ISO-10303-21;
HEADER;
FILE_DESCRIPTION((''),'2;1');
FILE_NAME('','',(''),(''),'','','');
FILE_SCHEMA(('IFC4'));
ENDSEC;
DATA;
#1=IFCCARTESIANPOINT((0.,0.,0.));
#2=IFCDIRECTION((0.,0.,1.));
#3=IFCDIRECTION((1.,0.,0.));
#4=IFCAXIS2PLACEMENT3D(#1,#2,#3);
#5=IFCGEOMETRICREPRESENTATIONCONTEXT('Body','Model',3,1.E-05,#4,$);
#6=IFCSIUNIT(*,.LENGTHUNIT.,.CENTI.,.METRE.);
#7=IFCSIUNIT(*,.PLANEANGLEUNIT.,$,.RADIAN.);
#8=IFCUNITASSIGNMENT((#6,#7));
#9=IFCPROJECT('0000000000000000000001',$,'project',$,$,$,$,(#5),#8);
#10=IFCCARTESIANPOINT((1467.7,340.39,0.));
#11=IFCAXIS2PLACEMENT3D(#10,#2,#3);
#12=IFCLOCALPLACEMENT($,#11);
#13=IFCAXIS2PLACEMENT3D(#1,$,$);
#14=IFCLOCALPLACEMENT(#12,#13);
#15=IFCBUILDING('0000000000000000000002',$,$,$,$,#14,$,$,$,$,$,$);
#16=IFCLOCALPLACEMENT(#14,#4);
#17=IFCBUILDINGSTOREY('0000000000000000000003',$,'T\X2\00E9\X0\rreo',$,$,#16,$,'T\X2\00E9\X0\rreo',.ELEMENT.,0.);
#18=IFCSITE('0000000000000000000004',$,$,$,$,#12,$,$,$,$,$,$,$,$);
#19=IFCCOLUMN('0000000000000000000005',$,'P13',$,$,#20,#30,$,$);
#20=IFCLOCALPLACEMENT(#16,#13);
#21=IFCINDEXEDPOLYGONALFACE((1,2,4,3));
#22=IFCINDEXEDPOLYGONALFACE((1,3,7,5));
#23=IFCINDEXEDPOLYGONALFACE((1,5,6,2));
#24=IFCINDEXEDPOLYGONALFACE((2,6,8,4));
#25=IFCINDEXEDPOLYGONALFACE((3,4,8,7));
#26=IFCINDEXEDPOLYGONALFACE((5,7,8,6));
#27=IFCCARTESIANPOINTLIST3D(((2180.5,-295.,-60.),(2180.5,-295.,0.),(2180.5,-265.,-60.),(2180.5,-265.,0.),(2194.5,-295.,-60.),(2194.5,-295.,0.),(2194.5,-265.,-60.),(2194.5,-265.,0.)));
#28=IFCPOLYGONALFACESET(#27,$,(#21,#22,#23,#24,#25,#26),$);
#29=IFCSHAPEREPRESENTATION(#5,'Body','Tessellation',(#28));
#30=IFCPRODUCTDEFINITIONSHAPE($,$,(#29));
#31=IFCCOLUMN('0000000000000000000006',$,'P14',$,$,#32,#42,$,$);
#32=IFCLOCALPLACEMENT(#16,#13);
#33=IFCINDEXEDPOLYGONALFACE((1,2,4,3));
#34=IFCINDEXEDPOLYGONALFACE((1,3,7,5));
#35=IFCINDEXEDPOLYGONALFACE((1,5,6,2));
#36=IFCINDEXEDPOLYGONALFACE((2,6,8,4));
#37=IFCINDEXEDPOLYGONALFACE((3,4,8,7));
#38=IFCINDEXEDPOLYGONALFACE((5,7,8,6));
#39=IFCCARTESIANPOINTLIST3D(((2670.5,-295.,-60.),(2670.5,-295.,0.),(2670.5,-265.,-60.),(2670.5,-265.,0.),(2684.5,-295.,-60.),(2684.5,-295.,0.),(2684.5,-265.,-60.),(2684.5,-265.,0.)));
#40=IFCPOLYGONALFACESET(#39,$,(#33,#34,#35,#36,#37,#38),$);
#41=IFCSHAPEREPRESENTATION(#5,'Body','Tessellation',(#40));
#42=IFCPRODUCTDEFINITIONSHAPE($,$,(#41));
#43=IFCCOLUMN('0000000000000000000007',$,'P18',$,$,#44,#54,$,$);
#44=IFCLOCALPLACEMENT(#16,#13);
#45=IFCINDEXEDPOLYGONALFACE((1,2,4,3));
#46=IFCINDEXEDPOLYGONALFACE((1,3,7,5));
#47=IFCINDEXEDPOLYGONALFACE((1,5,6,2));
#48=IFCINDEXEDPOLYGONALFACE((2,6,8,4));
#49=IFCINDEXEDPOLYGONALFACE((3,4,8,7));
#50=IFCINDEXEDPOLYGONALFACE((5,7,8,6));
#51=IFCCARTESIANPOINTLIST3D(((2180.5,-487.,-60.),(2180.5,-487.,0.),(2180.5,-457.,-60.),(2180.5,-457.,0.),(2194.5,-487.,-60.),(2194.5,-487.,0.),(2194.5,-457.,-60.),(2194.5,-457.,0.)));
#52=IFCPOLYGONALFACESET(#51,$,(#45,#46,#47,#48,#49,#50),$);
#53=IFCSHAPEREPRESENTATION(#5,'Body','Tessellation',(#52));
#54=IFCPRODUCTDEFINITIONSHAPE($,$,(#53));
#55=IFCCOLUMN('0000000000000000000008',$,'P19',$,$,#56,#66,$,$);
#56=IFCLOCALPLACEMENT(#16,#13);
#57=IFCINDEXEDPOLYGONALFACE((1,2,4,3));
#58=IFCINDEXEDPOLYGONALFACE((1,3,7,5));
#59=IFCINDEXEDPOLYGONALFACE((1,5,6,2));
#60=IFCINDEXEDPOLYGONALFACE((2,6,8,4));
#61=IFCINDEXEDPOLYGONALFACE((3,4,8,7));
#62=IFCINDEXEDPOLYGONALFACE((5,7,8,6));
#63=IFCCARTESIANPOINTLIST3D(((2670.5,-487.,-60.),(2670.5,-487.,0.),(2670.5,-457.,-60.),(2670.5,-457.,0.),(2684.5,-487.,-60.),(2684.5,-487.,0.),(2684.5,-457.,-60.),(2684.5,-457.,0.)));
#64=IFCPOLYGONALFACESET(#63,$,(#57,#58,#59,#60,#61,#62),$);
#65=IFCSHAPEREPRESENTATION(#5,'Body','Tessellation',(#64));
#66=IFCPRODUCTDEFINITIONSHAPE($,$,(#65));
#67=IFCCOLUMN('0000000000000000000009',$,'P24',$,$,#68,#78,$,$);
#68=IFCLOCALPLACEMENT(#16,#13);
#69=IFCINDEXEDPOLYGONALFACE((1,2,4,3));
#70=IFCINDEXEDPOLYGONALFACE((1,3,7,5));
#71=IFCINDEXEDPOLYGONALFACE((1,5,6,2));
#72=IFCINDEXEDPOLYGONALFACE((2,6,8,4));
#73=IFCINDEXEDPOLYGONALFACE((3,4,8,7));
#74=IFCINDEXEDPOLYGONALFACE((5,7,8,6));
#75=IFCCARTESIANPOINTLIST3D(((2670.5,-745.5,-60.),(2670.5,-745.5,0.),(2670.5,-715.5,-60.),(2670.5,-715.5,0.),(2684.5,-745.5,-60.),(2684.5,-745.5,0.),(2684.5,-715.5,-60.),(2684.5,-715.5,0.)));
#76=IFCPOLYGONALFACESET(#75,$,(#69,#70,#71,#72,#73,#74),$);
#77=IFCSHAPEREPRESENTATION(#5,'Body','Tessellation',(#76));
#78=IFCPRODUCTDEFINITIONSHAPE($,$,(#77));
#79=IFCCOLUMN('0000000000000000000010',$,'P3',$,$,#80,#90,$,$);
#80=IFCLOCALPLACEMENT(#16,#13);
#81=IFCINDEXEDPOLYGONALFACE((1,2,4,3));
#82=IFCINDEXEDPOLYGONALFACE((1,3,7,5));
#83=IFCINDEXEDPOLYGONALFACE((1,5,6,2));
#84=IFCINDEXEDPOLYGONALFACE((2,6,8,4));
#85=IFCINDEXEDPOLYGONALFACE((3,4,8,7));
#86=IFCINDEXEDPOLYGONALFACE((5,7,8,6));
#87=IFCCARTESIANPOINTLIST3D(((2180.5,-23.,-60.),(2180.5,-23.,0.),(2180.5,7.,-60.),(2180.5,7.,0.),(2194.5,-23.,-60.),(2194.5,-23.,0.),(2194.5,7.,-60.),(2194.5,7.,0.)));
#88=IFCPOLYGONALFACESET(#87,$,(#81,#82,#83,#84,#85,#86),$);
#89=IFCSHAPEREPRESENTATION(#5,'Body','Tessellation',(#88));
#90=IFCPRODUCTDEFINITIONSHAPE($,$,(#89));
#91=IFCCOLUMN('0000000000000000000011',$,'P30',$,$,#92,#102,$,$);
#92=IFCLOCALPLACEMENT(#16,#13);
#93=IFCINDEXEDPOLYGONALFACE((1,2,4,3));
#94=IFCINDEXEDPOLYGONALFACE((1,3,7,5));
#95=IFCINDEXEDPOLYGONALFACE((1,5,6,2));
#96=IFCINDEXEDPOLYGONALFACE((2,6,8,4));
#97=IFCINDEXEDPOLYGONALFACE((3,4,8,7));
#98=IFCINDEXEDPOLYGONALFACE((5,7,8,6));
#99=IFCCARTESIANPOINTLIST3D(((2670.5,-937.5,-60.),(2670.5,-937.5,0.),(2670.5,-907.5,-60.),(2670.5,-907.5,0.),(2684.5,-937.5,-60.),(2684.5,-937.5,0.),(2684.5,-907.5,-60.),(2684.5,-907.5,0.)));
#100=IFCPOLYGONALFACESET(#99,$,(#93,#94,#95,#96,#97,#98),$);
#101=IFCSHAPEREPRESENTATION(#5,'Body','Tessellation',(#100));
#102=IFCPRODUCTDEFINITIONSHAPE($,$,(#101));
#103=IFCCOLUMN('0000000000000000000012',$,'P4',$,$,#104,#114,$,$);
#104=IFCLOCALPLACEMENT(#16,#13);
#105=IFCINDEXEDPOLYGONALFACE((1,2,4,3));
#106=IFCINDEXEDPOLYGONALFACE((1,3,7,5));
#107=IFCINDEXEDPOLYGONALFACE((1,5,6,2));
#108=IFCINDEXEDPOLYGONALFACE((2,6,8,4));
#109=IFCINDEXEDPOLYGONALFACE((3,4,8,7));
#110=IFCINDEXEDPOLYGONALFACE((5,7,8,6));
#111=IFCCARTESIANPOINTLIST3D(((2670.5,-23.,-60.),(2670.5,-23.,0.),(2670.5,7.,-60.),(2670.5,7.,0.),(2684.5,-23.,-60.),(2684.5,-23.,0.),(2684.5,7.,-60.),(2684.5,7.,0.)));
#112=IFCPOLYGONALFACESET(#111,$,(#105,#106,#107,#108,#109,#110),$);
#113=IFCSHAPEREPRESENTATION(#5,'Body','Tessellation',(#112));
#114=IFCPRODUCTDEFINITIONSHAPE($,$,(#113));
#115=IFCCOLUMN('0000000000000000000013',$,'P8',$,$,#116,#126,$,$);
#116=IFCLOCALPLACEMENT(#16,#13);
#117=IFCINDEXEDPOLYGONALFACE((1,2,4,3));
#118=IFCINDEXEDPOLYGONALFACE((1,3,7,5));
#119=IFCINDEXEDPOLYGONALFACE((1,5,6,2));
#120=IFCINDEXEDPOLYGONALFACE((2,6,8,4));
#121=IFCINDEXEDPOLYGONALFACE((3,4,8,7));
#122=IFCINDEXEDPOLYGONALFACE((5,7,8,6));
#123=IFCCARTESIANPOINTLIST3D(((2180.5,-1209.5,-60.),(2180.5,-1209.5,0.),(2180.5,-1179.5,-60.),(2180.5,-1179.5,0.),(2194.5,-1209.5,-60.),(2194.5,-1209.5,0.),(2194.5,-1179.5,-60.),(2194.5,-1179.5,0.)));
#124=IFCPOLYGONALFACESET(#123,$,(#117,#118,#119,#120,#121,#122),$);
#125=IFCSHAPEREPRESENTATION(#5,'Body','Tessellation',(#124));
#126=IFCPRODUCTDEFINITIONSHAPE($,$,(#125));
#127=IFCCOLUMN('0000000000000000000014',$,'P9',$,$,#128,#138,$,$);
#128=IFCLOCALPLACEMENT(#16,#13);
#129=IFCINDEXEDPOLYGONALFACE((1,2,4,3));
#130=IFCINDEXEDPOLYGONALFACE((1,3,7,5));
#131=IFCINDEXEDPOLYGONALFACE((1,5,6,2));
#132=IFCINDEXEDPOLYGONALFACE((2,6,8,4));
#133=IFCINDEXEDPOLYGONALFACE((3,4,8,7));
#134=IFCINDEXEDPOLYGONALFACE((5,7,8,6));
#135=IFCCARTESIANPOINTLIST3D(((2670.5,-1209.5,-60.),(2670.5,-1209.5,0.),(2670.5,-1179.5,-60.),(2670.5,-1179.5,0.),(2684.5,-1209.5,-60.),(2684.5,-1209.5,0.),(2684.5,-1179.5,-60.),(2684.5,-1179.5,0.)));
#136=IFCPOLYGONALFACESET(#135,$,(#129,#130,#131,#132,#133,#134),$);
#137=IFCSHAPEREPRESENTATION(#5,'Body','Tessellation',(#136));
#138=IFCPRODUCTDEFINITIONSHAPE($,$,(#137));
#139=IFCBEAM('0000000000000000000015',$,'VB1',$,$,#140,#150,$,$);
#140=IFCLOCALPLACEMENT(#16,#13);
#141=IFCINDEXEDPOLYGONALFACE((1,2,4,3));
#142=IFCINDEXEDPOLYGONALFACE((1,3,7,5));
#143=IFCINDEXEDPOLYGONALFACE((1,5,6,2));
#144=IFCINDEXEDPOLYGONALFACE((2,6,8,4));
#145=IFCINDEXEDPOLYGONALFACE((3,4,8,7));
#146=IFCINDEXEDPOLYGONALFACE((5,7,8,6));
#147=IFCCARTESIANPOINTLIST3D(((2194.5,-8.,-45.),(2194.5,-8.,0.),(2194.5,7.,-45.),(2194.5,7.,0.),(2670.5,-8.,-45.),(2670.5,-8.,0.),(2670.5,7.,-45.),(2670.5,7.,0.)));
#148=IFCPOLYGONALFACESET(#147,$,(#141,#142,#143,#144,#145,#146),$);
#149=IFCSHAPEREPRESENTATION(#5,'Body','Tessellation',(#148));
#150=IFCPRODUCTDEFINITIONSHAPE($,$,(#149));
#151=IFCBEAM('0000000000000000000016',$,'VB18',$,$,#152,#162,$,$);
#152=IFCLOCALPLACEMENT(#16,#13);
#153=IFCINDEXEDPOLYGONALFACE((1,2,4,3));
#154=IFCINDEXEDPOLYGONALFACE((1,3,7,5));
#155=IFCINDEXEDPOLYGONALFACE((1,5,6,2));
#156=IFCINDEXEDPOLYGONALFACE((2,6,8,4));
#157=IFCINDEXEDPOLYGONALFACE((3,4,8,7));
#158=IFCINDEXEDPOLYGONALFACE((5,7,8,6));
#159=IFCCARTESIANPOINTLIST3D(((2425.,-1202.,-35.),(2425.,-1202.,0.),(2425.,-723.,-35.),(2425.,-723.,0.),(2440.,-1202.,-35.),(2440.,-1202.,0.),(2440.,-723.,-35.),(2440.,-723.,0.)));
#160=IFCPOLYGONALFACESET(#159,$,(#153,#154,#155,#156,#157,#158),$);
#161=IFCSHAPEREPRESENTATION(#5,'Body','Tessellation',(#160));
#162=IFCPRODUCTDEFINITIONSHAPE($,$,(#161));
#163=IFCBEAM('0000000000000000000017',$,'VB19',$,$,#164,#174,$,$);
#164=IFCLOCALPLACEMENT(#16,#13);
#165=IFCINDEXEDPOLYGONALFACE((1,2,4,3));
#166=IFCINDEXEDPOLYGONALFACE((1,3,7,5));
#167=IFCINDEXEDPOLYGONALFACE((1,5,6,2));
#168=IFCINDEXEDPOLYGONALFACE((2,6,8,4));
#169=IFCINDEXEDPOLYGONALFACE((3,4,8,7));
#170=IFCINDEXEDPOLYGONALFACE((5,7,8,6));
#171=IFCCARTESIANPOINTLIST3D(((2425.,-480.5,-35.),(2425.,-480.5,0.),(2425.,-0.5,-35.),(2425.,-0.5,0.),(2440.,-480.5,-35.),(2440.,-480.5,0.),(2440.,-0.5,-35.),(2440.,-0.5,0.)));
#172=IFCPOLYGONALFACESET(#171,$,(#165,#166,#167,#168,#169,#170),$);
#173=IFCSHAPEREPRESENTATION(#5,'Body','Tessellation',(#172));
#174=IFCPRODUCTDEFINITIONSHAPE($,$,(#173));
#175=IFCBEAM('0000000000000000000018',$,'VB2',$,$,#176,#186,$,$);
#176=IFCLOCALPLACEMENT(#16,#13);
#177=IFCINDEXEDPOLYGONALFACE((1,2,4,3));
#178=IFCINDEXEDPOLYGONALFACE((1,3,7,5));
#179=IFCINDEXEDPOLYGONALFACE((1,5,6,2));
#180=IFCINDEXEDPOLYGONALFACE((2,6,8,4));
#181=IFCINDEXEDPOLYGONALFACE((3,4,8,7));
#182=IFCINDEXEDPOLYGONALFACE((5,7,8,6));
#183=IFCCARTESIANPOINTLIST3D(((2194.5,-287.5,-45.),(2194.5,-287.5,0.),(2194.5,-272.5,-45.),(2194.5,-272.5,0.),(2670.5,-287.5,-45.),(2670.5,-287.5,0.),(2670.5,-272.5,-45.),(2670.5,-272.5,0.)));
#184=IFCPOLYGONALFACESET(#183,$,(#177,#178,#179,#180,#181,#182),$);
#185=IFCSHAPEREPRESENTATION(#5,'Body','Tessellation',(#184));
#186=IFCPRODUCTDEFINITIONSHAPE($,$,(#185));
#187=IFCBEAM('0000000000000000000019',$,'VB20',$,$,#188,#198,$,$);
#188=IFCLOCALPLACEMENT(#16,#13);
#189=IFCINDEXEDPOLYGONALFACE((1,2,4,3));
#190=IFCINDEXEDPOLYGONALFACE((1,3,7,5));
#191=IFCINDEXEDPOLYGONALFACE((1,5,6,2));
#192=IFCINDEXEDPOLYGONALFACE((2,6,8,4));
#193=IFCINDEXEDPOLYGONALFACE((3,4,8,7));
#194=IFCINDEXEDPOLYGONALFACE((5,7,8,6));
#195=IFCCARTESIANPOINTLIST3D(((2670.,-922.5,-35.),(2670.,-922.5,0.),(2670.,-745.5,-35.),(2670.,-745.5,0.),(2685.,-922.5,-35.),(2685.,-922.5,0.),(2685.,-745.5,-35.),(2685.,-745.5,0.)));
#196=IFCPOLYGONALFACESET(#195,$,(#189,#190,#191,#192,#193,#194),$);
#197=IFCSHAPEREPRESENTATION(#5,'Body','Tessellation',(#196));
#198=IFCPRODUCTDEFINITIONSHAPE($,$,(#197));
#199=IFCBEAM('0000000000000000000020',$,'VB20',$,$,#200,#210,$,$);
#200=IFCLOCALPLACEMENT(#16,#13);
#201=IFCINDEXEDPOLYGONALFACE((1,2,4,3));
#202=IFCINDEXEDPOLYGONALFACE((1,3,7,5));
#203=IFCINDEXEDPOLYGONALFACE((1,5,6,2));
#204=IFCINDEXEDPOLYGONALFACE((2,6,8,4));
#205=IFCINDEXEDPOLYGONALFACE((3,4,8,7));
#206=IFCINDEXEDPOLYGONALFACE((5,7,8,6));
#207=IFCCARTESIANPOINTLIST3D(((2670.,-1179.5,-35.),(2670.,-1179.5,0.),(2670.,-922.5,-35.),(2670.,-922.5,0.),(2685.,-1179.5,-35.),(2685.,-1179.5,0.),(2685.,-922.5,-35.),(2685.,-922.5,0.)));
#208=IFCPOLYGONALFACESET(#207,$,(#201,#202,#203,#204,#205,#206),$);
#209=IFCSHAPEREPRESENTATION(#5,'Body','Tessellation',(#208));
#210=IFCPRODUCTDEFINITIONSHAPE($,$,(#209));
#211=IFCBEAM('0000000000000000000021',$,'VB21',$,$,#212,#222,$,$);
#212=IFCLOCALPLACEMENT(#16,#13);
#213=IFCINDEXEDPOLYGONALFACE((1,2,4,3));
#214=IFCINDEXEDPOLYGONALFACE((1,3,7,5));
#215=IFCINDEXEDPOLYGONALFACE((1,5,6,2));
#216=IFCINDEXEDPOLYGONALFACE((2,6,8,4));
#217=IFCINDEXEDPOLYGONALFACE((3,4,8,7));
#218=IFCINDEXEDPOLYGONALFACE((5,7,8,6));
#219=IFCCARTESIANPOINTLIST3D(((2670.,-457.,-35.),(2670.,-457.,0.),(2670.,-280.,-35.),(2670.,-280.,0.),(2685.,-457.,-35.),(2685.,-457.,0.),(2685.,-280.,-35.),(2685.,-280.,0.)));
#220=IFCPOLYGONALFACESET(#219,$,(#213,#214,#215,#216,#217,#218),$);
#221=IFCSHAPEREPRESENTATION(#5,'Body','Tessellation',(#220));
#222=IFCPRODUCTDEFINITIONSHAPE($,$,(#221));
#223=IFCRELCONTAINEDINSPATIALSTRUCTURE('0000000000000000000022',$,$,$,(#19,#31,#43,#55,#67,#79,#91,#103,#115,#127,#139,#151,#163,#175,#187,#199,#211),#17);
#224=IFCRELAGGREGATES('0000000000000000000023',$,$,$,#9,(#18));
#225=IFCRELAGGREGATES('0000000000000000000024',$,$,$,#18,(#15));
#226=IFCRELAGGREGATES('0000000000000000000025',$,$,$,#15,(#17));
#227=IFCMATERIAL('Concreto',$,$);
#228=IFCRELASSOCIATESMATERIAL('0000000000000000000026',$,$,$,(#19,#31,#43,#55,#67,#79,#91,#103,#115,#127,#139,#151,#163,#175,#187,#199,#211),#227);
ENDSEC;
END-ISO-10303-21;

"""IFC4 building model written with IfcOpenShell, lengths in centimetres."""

from ifc_helpers import new_model, si_unit, frame, origin, origin_with_axes, origin_2d_with_axis, place, context, project, spatial, rectangle, extrude, material, element, save


model = new_model("IFC4")

# Units and contexts
model_context = context("Model", 3, precision=1e-05, world=origin_with_axes(), identifier="Body")
ifc_project = project(units=[si_unit("LENGTHUNIT", "METRE", prefix="CENTI"), si_unit("PLANEANGLEUNIT", "RADIAN")], contexts=[model_context])

# Site, building, storey
site_placement = place(None, frame((1467.7, 340.39, 0.0), z_axis=(0.0, 0.0, 1.0), x_axis=(1.0, 0.0, 0.0)))
site = spatial("IfcSite", under=ifc_project, at=site_placement)
building_placement = place(site_placement, origin())
building = spatial("IfcBuilding", under=site, at=building_placement)
storey_placement = place(building_placement, origin_with_axes())
storey = spatial("IfcBuildingStorey", under=building, at=storey_placement, Name="Térreo", LongName="Térreo", CompositionType="ELEMENT", Elevation=0.0)

# Columns
ifc_material = material(Name="Concreto")
for number, where, z_axis, x_axis, name in (
    (1, (2187.5, -280.0, 0.0), (0.0, 0.0, 1.0), (1.0, 0.0, 0.0), "P13"),
    (2, (2677.5, -280.0, 0.0), (0.0, 0.0, 1.0), (1.0, 0.0, 0.0), "P14"),
):
    element("IfcColumn", number, at=place(storey_placement, frame(where, z_axis=z_axis, x_axis=x_axis)), inside=storey, material=ifc_material, Name=name, context=model_context, shape_type="SolidModel", body=[
        extrude(rectangle(XDim=14.0, YDim=30.0, at=origin_2d_with_axis()), frame((0.0, 0.0, -60.0), z_axis=(0.0, 0.0, 1.0), x_axis=(1.0, 0.0, 0.0)), (0.0, 0.0, 1.0), 60.0),
    ])
for number, where, z_axis, x_axis, name in (
    (3, (2187.5, -472.0, 0.0), (0.0, 0.0, 1.0), (1.0, 0.0, 0.0), "P18"),
    (4, (2677.5, -472.0, 0.0), (0.0, 0.0, 1.0), (1.0, 0.0, 0.0), "P19"),
):
    element("IfcColumn", number, at=place(storey_placement, frame(where, z_axis=z_axis, x_axis=x_axis)), inside=storey, material=ifc_material, Name=name, context=model_context, shape_type="SolidModel", body=[
        extrude(rectangle(XDim=14.0, YDim=30.0, at=origin_2d_with_axis()), frame((0.0, 0.0, -60.0), z_axis=(0.0, 0.0, 1.0), x_axis=(-1.0, 0.0, 0.0)), (0.0, 0.0, 1.0), 60.0),
    ])
for number, where, z_axis, x_axis, name in (
    (5, (2677.5, -730.5, 0.0), (0.0, 0.0, 1.0), (1.0, 0.0, 0.0), "P24"),
    (6, (2187.5, -8.0, 0.0), (0.0, 0.0, 1.0), (1.0, 0.0, 0.0), "P3"),
    (7, (2677.5, -922.5, 0.0), (0.0, 0.0, 1.0), (1.0, 0.0, 0.0), "P30"),
    (8, (2677.5, -8.0, 0.0), (0.0, 0.0, 1.0), (1.0, 0.0, 0.0), "P4"),
    (9, (2187.5, -1194.5, 0.0), (0.0, 0.0, 1.0), (1.0, 0.0, 0.0), "P8"),
    (10, (2677.5, -1194.5, 0.0), (0.0, 0.0, 1.0), (1.0, 0.0, 0.0), "P9"),
):
    element("IfcColumn", number, at=place(storey_placement, frame(where, z_axis=z_axis, x_axis=x_axis)), inside=storey, material=ifc_material, Name=name, context=model_context, shape_type="SolidModel", body=[
        extrude(rectangle(XDim=14.0, YDim=30.0, at=origin_2d_with_axis()), frame((0.0, 0.0, -60.0), z_axis=(0.0, 0.0, 1.0), x_axis=(1.0, 0.0, 0.0)), (0.0, 0.0, 1.0), 60.0),
    ])

# Beams
beam_1_placement = place(storey_placement, frame((2432.5, -0.5, 0.0), z_axis=(0.0, 0.0, 1.0), x_axis=(1.0, 0.0, 0.0)))
element("IfcBeam", 11, at=beam_1_placement, inside=storey, material=ifc_material, Name="VB1", context=model_context, shape_type="SolidModel", body=[
    extrude(rectangle(XDim=15.0, YDim=45.0, at=origin_2d_with_axis()), frame((-238.0, 0.0, -22.5), z_axis=(1.0, 0.0, 0.0), x_axis=(0.0, 1.0, 0.0)), (0.0, 0.0, 1.0), 476.0),
])
beam_2_placement = place(storey_placement, frame((2432.5, -962.5, 0.0), z_axis=(0.0, 0.0, 1.0), x_axis=(1.0, 0.0, 0.0)))
element("IfcBeam", 12, at=beam_2_placement, inside=storey, material=ifc_material, Name="VB18", context=model_context, shape_type="SolidModel", body=[
    extrude(rectangle(XDim=15.0, YDim=35.0, at=origin_2d_with_axis()), frame((0.0, -239.5, -17.5), z_axis=(0.0, 1.0, 0.0), x_axis=(1.0, 0.0, 0.0)), (0.0, 0.0, 1.0), 479.0),
])
beam_3_placement = place(storey_placement, frame((2432.5, -240.5, 0.0), z_axis=(0.0, 0.0, 1.0), x_axis=(1.0, 0.0, 0.0)))
element("IfcBeam", 13, at=beam_3_placement, inside=storey, material=ifc_material, Name="VB19", context=model_context, shape_type="SolidModel", body=[
    extrude(rectangle(XDim=15.0, YDim=35.0, at=origin_2d_with_axis()), frame((0.0, -240.0, -17.5), z_axis=(0.0, 1.0, 0.0), x_axis=(1.0, 0.0, 0.0)), (0.0, 0.0, 1.0), 480.0),
])
beam_4_placement = place(storey_placement, frame((2432.5, -280.0, 0.0), z_axis=(0.0, 0.0, 1.0), x_axis=(1.0, 0.0, 0.0)))
element("IfcBeam", 14, at=beam_4_placement, inside=storey, material=ifc_material, Name="VB2", context=model_context, shape_type="SolidModel", body=[
    extrude(rectangle(XDim=15.0, YDim=45.0, at=origin_2d_with_axis()), frame((-238.0, 0.0, -22.5), z_axis=(1.0, 0.0, 0.0), x_axis=(0.0, 1.0, 0.0)), (0.0, 0.0, 1.0), 476.0),
])
beam_5_placement = place(storey_placement, frame((2677.5, -834.0, 0.0), z_axis=(0.0, 0.0, 1.0), x_axis=(1.0, 0.0, 0.0)))
element("IfcBeam", 15, at=beam_5_placement, inside=storey, material=ifc_material, Name="VB20", context=model_context, shape_type="SolidModel", body=[
    extrude(rectangle(XDim=15.0, YDim=35.0, at=origin_2d_with_axis()), frame((0.0, -88.5, -17.5), z_axis=(0.0, 1.0, 0.0), x_axis=(1.0, 0.0, 0.0)), (0.0, 0.0, 1.0), 177.0),
])
beam_6_placement = place(storey_placement, frame((2677.5, -1051.0, 0.0), z_axis=(0.0, 0.0, 1.0), x_axis=(1.0, 0.0, 0.0)))
element("IfcBeam", 16, at=beam_6_placement, inside=storey, material=ifc_material, Name="VB20", context=model_context, shape_type="SolidModel", body=[
    extrude(rectangle(XDim=15.0, YDim=35.0, at=origin_2d_with_axis()), frame((0.0, -128.5, -17.5), z_axis=(0.0, 1.0, 0.0), x_axis=(1.0, 0.0, 0.0)), (0.0, 0.0, 1.0), 257.0),
])
beam_7_placement = place(storey_placement, frame((2677.5, -368.5, 0.0), z_axis=(0.0, 0.0, 1.0), x_axis=(1.0, 0.0, 0.0)))
element("IfcBeam", 17, at=beam_7_placement, inside=storey, material=ifc_material, Name="VB21", context=model_context, shape_type="SolidModel", body=[
    extrude(rectangle(XDim=15.0, YDim=35.0, at=origin_2d_with_axis()), frame((0.0, -88.5, -17.5), z_axis=(0.0, 1.0, 0.0), x_axis=(1.0, 0.0, 0.0)), (0.0, 0.0, 1.0), 177.0),
])

save(model, "model.ifc")
